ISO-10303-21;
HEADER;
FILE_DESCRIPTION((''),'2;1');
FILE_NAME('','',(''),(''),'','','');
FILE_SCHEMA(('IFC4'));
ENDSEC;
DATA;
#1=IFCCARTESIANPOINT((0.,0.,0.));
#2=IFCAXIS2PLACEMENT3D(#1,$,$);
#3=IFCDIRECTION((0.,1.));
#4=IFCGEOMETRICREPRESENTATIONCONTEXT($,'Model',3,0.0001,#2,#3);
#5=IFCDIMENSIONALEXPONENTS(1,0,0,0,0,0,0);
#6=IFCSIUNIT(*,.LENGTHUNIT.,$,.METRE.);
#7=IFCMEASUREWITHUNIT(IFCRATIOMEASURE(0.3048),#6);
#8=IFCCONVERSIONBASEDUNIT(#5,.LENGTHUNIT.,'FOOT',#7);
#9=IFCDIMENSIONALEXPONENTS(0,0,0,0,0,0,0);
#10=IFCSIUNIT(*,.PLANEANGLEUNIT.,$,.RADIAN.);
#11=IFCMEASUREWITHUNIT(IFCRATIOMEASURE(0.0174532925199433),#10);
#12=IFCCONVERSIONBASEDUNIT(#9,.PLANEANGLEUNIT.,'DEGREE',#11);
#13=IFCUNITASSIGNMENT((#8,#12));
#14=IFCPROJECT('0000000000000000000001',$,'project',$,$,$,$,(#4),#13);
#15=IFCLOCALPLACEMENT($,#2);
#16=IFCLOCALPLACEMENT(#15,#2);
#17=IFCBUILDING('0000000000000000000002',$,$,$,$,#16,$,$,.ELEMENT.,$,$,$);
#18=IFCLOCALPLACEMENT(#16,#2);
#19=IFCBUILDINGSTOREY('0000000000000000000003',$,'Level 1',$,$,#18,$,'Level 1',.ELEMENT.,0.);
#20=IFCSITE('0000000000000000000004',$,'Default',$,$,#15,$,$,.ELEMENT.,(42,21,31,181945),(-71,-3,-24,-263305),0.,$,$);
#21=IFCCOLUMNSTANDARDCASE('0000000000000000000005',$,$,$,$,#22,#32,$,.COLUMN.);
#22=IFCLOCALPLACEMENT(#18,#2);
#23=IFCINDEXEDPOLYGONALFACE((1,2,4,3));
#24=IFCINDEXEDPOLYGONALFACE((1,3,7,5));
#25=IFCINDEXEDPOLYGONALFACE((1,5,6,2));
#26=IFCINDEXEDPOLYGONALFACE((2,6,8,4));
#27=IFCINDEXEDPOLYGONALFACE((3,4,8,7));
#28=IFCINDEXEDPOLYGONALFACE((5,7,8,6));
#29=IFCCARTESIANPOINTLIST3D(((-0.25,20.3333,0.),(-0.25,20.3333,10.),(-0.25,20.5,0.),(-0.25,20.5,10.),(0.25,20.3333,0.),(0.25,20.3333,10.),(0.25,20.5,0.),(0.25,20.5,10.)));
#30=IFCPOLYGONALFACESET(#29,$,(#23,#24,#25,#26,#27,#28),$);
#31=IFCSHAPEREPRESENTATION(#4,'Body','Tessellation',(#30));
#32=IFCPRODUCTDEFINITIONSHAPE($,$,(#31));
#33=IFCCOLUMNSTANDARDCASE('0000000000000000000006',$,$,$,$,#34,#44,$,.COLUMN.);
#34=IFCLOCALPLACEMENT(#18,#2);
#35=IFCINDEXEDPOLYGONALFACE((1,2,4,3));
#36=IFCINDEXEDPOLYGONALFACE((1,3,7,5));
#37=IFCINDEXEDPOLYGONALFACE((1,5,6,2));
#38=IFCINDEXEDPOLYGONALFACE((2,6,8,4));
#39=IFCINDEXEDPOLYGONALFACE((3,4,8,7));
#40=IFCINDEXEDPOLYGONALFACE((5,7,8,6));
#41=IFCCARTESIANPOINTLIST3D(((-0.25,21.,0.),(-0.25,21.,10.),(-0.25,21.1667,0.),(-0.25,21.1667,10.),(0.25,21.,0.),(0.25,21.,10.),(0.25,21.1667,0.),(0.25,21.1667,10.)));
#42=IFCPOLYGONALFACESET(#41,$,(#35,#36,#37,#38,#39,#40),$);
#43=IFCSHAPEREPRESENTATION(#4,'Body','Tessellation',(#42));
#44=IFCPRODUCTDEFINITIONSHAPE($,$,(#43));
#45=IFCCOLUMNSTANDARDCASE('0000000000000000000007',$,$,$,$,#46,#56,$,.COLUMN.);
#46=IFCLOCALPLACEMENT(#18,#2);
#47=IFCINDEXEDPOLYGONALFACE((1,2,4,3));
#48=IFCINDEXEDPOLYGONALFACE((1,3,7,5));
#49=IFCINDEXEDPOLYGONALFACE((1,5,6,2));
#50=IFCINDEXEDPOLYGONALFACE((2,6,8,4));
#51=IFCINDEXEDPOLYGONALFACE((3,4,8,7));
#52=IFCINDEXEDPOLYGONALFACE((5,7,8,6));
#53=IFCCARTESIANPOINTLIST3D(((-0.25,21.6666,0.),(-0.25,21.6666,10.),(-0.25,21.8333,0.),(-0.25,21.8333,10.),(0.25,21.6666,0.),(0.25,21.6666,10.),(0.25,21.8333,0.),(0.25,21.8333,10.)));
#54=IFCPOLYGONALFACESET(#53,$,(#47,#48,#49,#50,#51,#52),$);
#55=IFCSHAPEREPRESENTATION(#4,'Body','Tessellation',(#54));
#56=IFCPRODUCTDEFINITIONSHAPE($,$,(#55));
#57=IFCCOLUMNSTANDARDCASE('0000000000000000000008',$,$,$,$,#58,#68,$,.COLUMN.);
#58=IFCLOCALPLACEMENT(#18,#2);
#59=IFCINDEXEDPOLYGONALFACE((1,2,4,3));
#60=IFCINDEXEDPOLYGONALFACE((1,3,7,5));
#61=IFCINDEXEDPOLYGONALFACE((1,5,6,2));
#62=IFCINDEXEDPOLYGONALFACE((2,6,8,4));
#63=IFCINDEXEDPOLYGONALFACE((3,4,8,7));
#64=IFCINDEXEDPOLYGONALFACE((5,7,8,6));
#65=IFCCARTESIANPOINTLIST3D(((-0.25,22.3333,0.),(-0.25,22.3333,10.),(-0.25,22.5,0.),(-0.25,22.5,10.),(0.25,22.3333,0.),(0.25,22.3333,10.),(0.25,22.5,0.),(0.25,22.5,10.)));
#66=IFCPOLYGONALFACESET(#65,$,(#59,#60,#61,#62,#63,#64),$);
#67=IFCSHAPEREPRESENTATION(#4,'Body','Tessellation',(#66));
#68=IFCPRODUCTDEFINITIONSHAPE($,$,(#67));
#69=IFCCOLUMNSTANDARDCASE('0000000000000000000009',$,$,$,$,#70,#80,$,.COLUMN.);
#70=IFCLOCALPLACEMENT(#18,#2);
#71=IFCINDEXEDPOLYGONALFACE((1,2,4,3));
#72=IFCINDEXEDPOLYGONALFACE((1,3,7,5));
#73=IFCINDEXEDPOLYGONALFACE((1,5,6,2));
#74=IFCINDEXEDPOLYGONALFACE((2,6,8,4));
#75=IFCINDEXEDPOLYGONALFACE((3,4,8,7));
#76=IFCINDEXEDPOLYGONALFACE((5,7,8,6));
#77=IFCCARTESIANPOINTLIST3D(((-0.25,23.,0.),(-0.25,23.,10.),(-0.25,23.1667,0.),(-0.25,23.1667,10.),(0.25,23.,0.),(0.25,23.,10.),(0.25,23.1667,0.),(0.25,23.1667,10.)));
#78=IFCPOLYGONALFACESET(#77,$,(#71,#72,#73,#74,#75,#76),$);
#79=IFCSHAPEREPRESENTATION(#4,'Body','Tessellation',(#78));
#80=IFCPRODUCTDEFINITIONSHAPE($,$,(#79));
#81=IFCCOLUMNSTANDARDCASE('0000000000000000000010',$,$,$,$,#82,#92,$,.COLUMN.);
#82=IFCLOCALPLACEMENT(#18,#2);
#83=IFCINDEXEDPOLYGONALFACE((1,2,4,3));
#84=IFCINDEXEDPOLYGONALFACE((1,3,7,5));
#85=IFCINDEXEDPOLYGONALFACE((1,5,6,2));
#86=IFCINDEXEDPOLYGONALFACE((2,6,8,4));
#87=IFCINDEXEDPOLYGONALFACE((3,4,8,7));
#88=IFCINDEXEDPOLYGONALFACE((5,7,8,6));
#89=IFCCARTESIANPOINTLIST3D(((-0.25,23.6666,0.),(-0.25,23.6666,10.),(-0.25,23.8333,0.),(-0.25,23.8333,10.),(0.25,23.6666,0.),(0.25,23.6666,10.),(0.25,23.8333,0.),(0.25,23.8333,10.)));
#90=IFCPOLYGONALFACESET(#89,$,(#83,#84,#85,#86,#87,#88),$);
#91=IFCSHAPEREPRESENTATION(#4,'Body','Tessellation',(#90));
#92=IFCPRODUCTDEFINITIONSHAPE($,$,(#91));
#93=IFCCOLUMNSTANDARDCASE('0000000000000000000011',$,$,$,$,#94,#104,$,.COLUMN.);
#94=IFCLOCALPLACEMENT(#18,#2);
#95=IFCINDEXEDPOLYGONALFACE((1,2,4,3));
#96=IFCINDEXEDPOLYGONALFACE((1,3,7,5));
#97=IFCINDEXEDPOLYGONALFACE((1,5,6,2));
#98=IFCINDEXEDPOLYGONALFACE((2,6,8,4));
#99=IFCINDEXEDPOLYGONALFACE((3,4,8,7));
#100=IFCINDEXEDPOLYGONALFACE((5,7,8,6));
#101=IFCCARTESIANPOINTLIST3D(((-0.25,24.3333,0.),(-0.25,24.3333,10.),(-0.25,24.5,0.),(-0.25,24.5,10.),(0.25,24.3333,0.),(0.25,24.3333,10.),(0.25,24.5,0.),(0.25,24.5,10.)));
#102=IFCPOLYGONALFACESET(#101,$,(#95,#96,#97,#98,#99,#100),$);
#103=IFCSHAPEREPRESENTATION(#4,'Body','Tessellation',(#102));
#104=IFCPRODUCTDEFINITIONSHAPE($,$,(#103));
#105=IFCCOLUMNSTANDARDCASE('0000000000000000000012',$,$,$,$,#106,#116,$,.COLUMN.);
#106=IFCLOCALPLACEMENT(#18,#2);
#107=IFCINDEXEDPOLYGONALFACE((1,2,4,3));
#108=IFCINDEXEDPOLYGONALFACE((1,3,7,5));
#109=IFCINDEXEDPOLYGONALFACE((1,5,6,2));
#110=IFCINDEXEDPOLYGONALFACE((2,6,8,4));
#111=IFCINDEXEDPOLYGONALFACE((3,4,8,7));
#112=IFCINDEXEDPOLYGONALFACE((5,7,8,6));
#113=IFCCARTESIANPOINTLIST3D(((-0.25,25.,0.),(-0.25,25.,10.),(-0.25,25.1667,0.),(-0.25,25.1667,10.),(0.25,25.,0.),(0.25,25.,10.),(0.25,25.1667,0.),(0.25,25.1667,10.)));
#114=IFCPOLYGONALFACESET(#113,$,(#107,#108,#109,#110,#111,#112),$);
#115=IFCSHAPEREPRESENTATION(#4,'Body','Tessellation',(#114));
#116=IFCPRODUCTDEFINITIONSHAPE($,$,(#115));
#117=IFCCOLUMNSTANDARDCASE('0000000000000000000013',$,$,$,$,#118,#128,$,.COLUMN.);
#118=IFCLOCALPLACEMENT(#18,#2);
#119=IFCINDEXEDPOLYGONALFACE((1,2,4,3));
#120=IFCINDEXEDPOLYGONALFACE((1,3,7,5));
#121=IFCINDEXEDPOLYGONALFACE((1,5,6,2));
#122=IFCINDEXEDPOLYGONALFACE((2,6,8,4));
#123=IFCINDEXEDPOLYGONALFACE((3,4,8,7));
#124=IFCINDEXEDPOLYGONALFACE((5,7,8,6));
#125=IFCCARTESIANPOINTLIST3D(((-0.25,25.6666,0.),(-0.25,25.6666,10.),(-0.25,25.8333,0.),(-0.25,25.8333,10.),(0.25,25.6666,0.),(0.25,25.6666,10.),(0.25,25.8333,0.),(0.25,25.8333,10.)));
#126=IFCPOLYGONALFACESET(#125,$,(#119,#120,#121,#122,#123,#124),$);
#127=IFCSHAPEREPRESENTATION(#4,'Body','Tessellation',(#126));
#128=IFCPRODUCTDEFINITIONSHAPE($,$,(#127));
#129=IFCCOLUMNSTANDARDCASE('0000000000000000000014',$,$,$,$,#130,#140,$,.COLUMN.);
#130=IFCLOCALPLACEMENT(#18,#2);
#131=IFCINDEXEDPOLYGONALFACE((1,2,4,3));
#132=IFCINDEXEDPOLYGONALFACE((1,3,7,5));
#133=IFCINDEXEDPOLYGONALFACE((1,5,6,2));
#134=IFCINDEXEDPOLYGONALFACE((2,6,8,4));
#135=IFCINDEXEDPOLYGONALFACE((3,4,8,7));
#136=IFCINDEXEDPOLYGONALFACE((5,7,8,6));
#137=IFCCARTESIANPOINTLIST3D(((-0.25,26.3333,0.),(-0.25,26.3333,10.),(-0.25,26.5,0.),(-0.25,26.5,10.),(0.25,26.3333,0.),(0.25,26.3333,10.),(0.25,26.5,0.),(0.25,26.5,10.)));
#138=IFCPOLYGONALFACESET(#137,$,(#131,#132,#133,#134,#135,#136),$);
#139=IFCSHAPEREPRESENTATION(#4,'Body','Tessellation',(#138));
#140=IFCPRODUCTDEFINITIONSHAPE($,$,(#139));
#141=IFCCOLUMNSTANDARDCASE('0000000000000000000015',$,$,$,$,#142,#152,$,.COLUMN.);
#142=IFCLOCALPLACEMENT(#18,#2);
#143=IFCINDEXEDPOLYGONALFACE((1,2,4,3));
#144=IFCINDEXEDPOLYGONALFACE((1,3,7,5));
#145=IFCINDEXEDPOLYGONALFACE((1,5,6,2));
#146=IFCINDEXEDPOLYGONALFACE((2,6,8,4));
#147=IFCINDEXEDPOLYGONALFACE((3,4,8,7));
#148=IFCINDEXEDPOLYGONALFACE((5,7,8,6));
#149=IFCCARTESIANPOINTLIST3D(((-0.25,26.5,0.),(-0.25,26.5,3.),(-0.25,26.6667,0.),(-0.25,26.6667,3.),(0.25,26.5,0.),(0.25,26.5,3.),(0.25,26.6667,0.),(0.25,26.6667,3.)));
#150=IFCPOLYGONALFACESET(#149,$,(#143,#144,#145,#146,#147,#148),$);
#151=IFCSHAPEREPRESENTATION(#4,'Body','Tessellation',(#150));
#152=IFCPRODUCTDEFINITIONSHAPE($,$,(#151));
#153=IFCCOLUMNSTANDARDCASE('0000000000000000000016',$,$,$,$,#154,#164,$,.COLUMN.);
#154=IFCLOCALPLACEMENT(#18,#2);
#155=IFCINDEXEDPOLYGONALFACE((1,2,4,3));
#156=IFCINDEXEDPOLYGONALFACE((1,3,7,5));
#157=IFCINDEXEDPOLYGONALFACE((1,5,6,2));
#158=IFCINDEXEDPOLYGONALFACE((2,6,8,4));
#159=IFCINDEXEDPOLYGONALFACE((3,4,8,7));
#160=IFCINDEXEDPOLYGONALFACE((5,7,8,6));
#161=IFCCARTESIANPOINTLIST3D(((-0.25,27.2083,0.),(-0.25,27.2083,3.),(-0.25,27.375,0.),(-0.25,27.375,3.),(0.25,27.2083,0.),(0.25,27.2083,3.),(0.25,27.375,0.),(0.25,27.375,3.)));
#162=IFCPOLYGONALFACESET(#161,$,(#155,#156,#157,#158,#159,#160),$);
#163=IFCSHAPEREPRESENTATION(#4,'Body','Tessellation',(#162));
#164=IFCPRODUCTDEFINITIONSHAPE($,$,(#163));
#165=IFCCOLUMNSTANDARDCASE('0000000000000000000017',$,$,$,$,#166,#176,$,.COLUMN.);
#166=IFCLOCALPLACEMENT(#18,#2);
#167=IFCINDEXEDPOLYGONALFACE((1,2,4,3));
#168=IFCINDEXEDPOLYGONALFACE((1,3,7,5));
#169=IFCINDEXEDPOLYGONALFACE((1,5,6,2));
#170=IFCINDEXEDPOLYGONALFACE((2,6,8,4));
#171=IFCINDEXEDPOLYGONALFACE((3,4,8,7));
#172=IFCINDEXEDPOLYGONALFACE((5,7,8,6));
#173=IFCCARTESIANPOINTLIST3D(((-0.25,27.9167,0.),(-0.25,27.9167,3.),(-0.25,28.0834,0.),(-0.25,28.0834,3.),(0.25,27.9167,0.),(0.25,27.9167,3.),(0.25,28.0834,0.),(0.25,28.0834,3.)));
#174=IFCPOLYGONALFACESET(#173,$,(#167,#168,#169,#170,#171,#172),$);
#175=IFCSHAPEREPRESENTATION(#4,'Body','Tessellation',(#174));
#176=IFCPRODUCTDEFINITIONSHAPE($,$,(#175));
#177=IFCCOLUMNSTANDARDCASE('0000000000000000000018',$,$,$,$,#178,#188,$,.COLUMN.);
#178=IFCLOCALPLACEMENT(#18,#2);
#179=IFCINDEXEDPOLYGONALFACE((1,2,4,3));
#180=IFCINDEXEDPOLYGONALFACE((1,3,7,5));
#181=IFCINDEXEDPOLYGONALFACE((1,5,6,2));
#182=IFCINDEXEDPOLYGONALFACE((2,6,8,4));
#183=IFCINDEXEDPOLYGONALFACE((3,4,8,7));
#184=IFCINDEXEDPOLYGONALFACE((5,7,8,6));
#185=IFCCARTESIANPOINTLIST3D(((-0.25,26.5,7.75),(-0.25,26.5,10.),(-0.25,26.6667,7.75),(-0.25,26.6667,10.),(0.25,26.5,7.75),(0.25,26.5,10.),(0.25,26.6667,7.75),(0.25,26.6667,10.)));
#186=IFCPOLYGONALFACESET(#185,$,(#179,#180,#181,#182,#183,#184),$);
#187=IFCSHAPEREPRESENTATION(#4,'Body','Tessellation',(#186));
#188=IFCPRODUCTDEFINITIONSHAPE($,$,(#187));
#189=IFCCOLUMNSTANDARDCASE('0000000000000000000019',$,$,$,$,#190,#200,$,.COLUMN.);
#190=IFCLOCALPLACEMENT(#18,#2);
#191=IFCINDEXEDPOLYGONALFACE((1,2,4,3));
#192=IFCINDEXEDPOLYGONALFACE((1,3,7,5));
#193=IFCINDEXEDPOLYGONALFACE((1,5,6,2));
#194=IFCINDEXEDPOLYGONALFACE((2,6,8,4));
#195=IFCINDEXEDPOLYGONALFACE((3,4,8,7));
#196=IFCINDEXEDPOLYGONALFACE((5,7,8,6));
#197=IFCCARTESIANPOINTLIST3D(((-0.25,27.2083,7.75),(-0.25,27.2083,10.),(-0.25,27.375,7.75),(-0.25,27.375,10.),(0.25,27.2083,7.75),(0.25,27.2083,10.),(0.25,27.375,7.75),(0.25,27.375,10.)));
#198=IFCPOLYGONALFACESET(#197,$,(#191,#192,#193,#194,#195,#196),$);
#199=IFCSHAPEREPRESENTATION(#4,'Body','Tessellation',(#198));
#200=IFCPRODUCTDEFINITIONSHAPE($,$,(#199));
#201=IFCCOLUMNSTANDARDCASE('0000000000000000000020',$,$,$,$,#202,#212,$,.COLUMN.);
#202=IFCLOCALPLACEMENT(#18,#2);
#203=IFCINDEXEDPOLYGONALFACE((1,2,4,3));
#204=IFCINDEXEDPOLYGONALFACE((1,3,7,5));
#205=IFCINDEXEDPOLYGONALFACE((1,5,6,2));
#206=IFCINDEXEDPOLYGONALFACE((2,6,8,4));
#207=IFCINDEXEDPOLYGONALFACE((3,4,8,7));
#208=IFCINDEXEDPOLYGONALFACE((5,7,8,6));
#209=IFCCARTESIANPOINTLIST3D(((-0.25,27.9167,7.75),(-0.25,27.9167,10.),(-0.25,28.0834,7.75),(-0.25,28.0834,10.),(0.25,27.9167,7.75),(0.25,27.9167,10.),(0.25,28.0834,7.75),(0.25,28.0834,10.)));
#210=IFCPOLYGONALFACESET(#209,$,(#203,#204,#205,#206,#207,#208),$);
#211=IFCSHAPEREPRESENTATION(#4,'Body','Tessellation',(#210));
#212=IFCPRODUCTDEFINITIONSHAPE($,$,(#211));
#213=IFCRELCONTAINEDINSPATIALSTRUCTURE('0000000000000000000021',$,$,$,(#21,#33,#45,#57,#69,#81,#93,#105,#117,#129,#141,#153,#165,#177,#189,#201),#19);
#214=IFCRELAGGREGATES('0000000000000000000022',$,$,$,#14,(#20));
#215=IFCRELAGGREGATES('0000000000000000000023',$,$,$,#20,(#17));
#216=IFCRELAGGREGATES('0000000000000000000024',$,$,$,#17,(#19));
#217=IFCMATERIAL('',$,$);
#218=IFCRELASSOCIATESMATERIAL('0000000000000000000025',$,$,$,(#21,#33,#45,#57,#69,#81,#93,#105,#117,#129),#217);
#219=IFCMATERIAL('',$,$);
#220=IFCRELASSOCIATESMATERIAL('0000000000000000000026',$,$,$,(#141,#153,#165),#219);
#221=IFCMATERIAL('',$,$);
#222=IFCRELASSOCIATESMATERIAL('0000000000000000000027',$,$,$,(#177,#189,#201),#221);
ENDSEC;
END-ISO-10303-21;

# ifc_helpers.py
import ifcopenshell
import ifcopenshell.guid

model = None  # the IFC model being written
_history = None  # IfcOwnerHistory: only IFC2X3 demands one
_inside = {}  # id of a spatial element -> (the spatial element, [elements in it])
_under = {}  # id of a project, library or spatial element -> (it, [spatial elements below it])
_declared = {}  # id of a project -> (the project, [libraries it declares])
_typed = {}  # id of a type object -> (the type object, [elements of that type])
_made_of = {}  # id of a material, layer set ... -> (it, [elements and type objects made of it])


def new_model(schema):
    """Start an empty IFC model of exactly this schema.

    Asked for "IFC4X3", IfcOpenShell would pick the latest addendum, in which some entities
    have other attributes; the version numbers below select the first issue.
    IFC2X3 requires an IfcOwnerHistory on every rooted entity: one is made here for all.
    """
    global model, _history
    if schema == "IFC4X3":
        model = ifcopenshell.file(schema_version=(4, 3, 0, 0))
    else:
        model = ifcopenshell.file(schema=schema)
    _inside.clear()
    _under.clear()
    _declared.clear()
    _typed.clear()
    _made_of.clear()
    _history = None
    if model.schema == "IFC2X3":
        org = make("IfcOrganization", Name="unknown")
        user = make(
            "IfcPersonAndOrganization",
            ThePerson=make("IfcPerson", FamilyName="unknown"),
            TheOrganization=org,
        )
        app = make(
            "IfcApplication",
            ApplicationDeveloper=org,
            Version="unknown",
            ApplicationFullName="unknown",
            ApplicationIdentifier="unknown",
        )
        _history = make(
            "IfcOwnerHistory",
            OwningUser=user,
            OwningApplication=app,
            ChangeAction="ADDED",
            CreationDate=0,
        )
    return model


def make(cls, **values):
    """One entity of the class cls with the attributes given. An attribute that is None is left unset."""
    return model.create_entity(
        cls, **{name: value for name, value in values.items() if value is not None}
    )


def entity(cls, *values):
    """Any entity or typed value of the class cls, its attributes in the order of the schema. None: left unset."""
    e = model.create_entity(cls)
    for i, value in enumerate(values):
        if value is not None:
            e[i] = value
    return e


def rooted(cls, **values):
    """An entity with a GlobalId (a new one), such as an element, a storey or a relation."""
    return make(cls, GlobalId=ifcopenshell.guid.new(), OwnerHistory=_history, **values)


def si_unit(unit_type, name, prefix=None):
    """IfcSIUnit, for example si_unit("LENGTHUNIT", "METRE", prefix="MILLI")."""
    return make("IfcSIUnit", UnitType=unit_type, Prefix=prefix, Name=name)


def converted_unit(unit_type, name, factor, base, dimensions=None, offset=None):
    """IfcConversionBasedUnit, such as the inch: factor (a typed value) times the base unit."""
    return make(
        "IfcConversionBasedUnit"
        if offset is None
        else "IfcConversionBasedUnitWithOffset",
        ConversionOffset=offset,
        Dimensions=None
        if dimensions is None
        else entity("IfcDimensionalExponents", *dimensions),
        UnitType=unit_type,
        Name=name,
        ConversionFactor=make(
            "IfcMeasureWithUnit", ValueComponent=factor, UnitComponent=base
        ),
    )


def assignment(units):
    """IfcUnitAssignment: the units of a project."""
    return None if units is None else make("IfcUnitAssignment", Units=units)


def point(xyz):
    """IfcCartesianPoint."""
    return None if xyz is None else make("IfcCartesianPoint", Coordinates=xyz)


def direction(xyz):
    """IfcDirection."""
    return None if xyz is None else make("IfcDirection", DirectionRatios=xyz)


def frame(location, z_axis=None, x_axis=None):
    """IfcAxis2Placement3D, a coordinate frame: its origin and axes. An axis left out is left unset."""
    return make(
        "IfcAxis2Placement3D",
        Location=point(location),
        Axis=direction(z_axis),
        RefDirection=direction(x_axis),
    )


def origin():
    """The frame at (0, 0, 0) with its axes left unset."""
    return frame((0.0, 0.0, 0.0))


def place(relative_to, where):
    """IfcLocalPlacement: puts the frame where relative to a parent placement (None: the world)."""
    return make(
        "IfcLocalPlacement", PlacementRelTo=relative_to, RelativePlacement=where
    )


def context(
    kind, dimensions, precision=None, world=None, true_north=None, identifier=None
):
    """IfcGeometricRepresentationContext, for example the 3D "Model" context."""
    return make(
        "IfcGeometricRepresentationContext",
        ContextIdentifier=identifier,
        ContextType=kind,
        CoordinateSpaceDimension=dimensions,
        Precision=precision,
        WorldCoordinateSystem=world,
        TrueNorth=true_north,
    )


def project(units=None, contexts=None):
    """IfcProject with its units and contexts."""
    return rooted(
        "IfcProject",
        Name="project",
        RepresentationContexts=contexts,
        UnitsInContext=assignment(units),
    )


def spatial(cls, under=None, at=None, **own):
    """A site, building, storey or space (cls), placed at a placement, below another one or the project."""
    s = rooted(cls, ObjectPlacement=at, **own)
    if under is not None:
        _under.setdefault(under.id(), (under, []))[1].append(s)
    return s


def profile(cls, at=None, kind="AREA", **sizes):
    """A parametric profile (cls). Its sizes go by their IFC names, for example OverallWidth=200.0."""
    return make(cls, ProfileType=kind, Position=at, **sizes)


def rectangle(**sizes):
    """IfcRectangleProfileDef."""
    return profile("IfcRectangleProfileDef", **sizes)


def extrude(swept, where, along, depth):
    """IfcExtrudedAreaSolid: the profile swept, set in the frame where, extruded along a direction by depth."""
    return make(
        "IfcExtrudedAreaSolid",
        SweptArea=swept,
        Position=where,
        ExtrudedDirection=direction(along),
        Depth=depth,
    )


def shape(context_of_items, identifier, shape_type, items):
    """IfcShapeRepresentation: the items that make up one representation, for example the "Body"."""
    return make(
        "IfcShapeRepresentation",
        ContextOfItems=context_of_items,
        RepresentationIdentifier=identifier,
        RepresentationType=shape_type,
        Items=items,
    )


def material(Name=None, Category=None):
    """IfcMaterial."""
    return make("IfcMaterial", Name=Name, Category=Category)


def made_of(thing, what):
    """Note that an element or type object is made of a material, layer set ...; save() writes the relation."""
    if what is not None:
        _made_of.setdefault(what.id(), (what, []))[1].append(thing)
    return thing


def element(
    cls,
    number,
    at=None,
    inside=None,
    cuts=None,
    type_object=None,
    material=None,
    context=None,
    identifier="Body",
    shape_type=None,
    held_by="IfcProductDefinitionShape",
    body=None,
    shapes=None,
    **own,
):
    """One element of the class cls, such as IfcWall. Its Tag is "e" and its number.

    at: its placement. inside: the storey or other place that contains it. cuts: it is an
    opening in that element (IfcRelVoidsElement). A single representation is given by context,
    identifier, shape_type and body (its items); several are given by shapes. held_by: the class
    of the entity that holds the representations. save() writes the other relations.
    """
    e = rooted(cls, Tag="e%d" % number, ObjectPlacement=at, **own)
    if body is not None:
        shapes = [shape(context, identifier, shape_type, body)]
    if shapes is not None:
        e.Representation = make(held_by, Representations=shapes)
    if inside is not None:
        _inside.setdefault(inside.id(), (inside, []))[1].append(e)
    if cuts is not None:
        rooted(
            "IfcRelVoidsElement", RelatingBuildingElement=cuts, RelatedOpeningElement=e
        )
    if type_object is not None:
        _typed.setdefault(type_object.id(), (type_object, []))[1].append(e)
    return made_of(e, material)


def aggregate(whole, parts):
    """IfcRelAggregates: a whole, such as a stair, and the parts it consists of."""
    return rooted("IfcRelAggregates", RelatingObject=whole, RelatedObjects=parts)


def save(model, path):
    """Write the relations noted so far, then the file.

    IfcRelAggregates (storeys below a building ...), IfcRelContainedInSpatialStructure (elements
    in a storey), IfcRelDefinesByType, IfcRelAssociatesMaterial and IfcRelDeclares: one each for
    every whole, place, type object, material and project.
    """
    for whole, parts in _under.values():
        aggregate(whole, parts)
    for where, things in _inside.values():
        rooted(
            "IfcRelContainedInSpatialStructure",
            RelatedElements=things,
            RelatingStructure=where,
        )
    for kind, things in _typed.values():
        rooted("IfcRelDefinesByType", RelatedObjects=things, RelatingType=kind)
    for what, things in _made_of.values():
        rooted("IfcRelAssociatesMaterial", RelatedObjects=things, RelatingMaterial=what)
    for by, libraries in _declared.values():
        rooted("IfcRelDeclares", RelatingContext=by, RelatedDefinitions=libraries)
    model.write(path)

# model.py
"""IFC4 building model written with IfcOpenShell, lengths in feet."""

from ifc_helpers import new_model, entity, si_unit, converted_unit, direction, frame, origin, place, context, project, spatial, rectangle, extrude, material, element, save


model = new_model("IFC4")

# Units and contexts
model_context = context("Model", 3, precision=0.0001, world=origin(), true_north=direction((0.0, 1.0)))
ifc_project = project(units=[converted_unit("LENGTHUNIT", "FOOT", entity("IfcRatioMeasure", 0.3048), si_unit("LENGTHUNIT", "METRE"), dimensions=[1, 0, 0, 0, 0, 0, 0]), converted_unit("PLANEANGLEUNIT", "DEGREE", entity("IfcRatioMeasure", 0.0174532925199433), si_unit("PLANEANGLEUNIT", "RADIAN"), dimensions=[0, 0, 0, 0, 0, 0, 0])], contexts=[model_context])

# Site, building, storey
site_placement = place(None, origin())
site = spatial("IfcSite", under=ifc_project, at=site_placement, Name="Default", CompositionType="ELEMENT", RefLatitude=(42, 21, 31, 181945), RefLongitude=(-71, -3, -24, -263305), RefElevation=0.0)
building_placement = place(site_placement, origin())
building = spatial("IfcBuilding", under=site, at=building_placement, CompositionType="ELEMENT")
storey_placement = place(building_placement, origin())
storey = spatial("IfcBuildingStorey", under=building, at=storey_placement, Name="Level 1", LongName="Level 1", CompositionType="ELEMENT", Elevation=0.0)

# Columns
ifc_material_1 = material(Name="")
placement = place(storey_placement, frame((0.0, -0.25, 0.0), z_axis=(0.0, 0.0, 1.0), x_axis=(0.0, 1.0, 0.0)))
for number, where, z_axis, x_axis in (
    (1, (20.6667, 0.0, 0.0), (0.0, 0.0, 1.0), (1.0, 0.0, 0.0)),
    (2, (21.3333, 0.0, 0.0), (0.0, 0.0, 1.0), (1.0, 0.0, 0.0)),
    (3, (22.0, 0.0, 0.0), (0.0, 0.0, 1.0), (1.0, 0.0, 0.0)),
    (4, (22.6667, 0.0, 0.0), (0.0, 0.0, 1.0), (1.0, 0.0, 0.0)),
    (5, (23.3333, 0.0, 0.0), (0.0, 0.0, 1.0), (1.0, 0.0, 0.0)),
    (6, (24.0, 0.0, 0.0), (0.0, 0.0, 1.0), (1.0, 0.0, 0.0)),
    (7, (24.6667, 0.0, 0.0), (0.0, 0.0, 1.0), (1.0, 0.0, 0.0)),
    (8, (25.3333, 0.0, 0.0), (0.0, 0.0, 1.0), (1.0, 0.0, 0.0)),
    (9, (26.0, 0.0, 0.0), (0.0, 0.0, 1.0), (1.0, 0.0, 0.0)),
    (10, (26.6667, 0.0, 0.0), (0.0, 0.0, 1.0), (1.0, 0.0, 0.0)),
):
    element("IfcColumnStandardCase", number, at=place(placement, frame(where, z_axis=z_axis, x_axis=x_axis)), inside=storey, material=ifc_material_1, PredefinedType="COLUMN", context=model_context, shape_type="SweptSolid", body=[
        extrude(rectangle(XDim=0.1667, YDim=0.5), origin(), (0.0, 0.0, 1.0), 10.0),
    ])
ifc_material_2 = material(Name="")
for number, where, z_axis, x_axis in (
    (11, (26.8334, 0.0, 0.0), (0.0, 0.0, 1.0), (1.0, 0.0, 0.0)),
    (12, (27.5417, 0.0, 0.0), (0.0, 0.0, 1.0), (1.0, 0.0, 0.0)),
    (13, (28.25, 0.0, 0.0), (0.0, 0.0, 1.0), (1.0, 0.0, 0.0)),
):
    element("IfcColumnStandardCase", number, at=place(placement, frame(where, z_axis=z_axis, x_axis=x_axis)), inside=storey, material=ifc_material_2, PredefinedType="COLUMN", context=model_context, shape_type="SweptSolid", body=[
        extrude(rectangle(XDim=0.1667, YDim=0.5), origin(), (0.0, 0.0, 1.0), 3.0),
    ])
ifc_material_3 = material(Name="")
for number, where, z_axis, x_axis in (
    (14, (26.8334, 0.0, 7.75), (0.0, 0.0, 1.0), (1.0, 0.0, 0.0)),
    (15, (27.5417, 0.0, 7.75), (0.0, 0.0, 1.0), (1.0, 0.0, 0.0)),
    (16, (28.25, 0.0, 7.75), (0.0, 0.0, 1.0), (1.0, 0.0, 0.0)),
):
    element("IfcColumnStandardCase", number, at=place(placement, frame(where, z_axis=z_axis, x_axis=x_axis)), inside=storey, material=ifc_material_3, PredefinedType="COLUMN", context=model_context, shape_type="SweptSolid", body=[
        extrude(rectangle(XDim=0.1667, YDim=0.5), origin(), (0.0, 0.0, 1.0), 2.25),
    ])

save(model, "model.ifc")
